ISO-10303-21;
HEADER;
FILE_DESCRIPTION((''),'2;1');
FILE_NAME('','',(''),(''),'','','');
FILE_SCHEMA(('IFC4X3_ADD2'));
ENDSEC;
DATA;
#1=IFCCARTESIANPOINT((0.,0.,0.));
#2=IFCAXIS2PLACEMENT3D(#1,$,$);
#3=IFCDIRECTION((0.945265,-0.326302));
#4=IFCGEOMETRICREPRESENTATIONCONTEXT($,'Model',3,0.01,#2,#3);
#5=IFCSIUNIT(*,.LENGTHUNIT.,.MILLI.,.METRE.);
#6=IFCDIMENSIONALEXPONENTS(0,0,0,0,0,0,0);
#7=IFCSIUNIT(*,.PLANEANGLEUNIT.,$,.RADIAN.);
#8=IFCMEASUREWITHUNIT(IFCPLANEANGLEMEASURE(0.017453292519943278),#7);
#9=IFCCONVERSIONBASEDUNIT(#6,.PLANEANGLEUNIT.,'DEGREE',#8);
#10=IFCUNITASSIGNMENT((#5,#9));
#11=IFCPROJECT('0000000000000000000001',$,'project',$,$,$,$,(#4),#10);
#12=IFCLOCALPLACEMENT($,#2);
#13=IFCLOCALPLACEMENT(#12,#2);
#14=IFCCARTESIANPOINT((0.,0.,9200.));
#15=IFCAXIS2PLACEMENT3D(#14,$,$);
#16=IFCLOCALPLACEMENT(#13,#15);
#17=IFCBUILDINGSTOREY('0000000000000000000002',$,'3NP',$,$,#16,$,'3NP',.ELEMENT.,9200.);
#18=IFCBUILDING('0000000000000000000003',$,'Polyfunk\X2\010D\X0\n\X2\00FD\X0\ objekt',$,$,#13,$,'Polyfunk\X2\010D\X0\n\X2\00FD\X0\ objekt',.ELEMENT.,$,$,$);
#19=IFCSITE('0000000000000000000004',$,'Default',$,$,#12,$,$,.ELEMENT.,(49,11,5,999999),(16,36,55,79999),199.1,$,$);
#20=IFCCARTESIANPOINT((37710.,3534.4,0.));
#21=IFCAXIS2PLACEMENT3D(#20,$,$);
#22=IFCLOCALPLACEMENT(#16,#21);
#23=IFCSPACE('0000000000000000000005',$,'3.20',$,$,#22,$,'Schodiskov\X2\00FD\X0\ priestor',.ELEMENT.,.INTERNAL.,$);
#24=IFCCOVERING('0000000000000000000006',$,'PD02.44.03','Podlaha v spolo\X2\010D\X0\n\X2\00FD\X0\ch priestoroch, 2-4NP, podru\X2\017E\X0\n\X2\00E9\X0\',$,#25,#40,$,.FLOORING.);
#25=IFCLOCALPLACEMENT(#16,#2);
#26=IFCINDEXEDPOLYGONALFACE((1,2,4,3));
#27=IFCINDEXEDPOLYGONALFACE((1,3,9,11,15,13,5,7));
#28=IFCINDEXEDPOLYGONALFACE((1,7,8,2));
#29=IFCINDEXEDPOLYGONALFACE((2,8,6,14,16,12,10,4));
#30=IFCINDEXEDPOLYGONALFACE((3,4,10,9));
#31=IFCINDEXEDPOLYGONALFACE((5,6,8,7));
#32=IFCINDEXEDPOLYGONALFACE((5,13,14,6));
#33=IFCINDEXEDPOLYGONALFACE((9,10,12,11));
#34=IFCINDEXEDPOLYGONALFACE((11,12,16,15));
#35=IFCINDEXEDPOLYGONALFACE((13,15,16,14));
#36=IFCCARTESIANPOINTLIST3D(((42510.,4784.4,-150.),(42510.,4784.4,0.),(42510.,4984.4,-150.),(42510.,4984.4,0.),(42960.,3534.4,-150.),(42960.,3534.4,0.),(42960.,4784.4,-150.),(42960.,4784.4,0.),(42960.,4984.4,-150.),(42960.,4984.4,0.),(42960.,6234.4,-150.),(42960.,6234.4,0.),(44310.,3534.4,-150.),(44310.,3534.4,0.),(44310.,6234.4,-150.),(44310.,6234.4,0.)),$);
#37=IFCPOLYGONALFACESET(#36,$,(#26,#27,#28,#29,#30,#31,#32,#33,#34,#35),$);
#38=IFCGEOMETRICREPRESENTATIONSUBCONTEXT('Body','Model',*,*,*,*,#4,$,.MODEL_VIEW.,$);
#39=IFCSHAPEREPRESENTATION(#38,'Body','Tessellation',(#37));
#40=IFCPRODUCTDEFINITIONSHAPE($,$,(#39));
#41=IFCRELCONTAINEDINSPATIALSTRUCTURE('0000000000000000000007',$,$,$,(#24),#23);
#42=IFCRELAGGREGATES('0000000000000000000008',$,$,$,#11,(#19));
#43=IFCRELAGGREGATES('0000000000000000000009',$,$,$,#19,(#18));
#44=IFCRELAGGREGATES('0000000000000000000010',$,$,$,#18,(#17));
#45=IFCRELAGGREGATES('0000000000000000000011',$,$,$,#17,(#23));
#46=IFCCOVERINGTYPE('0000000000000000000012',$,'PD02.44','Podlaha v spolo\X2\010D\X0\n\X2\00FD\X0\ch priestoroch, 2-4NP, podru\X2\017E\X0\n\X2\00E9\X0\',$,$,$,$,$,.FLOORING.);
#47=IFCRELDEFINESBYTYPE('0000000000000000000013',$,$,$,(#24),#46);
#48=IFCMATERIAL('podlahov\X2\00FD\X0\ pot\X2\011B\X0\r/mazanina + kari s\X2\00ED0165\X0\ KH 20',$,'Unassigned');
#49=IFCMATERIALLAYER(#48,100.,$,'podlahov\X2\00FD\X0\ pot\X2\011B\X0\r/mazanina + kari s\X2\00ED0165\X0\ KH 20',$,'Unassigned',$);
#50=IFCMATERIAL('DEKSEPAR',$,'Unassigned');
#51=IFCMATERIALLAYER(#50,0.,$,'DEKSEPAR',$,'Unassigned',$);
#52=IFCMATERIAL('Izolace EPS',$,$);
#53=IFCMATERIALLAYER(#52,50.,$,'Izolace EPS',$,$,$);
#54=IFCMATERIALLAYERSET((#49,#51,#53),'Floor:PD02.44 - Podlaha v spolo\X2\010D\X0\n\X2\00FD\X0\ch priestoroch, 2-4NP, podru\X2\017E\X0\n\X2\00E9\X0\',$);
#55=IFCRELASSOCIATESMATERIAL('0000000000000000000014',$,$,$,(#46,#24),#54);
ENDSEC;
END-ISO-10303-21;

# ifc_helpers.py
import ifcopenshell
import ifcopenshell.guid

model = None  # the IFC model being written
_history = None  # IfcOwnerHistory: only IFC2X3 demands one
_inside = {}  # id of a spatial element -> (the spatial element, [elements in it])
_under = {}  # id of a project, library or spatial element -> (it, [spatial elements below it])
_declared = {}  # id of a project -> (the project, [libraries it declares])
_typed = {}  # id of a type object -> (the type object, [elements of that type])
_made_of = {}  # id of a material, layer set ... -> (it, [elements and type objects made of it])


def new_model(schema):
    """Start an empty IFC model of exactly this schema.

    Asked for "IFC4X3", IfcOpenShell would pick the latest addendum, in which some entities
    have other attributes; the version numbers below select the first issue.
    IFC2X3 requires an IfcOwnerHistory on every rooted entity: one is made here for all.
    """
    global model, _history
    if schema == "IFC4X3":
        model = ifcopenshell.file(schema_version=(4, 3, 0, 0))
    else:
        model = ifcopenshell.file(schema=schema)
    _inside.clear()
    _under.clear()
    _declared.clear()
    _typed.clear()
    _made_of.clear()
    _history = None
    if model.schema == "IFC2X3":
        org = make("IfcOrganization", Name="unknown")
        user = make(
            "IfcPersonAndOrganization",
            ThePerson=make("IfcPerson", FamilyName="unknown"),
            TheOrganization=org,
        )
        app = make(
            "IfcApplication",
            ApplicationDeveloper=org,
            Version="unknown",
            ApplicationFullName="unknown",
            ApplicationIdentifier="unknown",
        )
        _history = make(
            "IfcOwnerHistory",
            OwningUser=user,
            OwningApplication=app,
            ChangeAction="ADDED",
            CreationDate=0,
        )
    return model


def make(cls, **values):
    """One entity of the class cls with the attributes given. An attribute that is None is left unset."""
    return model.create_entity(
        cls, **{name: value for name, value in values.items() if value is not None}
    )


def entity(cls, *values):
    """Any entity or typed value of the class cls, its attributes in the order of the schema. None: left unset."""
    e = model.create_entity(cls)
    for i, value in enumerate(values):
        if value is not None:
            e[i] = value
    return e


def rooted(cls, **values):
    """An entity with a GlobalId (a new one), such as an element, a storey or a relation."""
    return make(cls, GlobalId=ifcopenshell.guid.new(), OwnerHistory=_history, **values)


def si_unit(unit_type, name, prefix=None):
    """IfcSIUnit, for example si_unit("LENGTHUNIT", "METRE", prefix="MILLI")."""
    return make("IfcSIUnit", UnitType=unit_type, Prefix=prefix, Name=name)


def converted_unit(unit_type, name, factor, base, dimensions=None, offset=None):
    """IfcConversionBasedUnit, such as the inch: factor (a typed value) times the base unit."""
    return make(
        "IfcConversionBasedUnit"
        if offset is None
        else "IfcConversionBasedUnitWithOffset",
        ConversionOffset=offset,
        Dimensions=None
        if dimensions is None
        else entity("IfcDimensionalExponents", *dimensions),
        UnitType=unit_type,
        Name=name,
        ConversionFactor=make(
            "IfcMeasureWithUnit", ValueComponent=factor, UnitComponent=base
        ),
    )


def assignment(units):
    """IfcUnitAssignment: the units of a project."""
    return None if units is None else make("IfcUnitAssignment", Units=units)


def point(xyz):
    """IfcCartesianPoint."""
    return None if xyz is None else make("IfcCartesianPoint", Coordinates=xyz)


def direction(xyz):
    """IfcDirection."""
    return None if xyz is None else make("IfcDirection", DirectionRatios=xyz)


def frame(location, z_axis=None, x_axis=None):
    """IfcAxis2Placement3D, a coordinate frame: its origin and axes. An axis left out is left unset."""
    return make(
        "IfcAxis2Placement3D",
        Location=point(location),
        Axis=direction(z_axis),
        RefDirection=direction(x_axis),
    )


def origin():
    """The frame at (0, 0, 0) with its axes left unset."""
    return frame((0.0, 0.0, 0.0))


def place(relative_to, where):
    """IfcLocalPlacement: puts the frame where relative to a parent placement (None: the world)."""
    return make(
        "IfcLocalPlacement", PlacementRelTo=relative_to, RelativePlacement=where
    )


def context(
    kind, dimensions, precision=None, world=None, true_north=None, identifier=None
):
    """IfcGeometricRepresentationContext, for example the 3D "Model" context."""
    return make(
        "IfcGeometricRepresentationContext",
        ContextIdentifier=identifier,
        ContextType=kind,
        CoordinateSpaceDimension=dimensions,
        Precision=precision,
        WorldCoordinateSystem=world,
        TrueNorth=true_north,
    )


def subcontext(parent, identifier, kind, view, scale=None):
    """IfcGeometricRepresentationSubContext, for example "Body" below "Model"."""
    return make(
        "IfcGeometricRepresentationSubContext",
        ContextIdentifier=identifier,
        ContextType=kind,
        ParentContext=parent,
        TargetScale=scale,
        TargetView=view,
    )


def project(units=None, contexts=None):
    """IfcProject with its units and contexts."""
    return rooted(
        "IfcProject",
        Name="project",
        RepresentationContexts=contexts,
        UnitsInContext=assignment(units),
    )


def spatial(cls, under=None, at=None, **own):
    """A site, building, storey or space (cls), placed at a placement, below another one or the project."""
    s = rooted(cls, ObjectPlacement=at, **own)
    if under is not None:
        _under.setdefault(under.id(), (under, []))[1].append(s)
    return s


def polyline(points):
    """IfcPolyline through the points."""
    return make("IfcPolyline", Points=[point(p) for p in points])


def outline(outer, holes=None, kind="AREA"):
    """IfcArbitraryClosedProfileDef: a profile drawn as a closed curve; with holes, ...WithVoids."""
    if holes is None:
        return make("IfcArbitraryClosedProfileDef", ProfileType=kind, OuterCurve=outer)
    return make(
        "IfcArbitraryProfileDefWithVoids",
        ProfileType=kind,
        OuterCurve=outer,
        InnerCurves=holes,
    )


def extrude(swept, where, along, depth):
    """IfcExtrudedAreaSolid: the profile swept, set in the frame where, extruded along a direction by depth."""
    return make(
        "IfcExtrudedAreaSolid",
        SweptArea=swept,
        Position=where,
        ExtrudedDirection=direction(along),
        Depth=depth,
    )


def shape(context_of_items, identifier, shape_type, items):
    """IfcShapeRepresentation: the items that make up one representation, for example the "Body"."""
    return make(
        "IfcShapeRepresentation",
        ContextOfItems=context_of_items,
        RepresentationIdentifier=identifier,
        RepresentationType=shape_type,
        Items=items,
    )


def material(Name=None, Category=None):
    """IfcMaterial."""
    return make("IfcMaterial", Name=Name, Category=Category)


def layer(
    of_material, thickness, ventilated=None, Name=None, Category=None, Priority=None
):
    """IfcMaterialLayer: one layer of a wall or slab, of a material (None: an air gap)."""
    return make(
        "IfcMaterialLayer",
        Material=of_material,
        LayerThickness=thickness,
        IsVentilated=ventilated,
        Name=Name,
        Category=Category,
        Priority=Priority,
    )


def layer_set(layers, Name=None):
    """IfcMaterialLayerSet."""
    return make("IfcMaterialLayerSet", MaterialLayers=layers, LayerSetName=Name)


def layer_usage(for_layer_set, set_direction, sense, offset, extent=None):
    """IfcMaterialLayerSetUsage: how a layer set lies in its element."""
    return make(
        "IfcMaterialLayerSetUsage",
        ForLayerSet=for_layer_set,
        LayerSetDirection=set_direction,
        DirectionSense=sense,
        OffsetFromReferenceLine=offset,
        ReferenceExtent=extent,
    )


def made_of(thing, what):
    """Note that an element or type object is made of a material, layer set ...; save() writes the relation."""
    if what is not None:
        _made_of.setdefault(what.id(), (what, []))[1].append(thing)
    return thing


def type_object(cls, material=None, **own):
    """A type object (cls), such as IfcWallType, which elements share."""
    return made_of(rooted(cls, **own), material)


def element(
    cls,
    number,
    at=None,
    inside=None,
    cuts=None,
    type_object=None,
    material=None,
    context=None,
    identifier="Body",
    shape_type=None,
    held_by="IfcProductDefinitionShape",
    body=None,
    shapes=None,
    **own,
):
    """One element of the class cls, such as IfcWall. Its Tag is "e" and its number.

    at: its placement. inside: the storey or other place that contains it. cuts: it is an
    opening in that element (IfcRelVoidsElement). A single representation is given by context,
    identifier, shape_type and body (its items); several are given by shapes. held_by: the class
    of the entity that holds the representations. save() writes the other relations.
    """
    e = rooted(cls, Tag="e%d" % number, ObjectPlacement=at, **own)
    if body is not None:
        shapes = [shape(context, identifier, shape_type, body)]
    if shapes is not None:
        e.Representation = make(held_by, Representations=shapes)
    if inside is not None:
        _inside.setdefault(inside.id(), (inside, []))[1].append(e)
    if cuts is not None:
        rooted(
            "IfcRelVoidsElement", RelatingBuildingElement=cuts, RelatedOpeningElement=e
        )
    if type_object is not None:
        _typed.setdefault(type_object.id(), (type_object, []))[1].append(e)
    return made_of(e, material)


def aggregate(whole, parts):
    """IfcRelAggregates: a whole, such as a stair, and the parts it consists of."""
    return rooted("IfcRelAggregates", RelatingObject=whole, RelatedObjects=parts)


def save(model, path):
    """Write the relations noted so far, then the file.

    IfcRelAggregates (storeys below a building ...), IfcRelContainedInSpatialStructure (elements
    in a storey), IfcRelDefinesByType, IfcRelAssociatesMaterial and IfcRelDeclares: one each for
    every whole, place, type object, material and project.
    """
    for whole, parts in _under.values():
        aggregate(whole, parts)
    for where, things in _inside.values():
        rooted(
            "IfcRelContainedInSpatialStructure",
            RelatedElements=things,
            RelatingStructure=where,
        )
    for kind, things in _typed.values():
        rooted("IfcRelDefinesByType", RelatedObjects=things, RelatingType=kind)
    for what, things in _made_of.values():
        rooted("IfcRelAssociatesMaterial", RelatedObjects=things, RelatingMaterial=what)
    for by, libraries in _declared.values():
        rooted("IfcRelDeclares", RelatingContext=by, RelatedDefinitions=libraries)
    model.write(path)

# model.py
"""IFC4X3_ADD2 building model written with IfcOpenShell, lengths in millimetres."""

from ifc_helpers import new_model, entity, si_unit, converted_unit, direction, frame, origin, place, context, subcontext, project, spatial, polyline, outline, extrude, material, layer, layer_set, layer_usage, type_object, element, save


model = new_model("IFC4X3_ADD2")

# Units and contexts
model_context = context("Model", 3, precision=0.01, world=origin(), true_north=direction((0.945265, -0.326302)))
body_context = subcontext(model_context, "Body", "Model", "MODEL_VIEW")
ifc_project = project(units=[si_unit("LENGTHUNIT", "METRE", prefix="MILLI"), converted_unit("PLANEANGLEUNIT", "DEGREE", entity("IfcPlaneAngleMeasure", 0.017453292519943278), si_unit("PLANEANGLEUNIT", "RADIAN"), dimensions=[0, 0, 0, 0, 0, 0, 0])], contexts=[model_context])

# Site, building, storey
site_placement = place(None, origin())
site = spatial("IfcSite", under=ifc_project, at=site_placement, Name="Default", CompositionType="ELEMENT", RefLatitude=(49, 11, 5, 999999), RefLongitude=(16, 36, 55, 79999), RefElevation=199.1)
building_placement = place(site_placement, origin())
building = spatial("IfcBuilding", under=site, at=building_placement, Name="Polyfunkčný objekt", LongName="Polyfunkčný objekt", CompositionType="ELEMENT")
storey_placement = place(building_placement, frame((0.0, 0.0, 9200.0)))
storey = spatial("IfcBuildingStorey", under=building, at=storey_placement, Name="3NP", LongName="3NP", CompositionType="ELEMENT", Elevation=9200.0)

# Shared definitions
space_1_placement = place(storey_placement, frame((37710.0, 3534.4, 0.0)))
space_1 = spatial("IfcSpace", under=storey, at=space_1_placement, Name="3.20", LongName="Schodiskový priestor", CompositionType="ELEMENT", PredefinedType="INTERNAL")

# Covering
ifc_material_1 = material(Name="podlahový potěr/mazanina + kari síť KH 20", Category="Unassigned")
ifc_layer_1 = layer(ifc_material_1, 100.0, Name="podlahový potěr/mazanina + kari síť KH 20", Category="Unassigned")
ifc_material_2 = material(Name="DEKSEPAR", Category="Unassigned")
ifc_layer_2 = layer(ifc_material_2, 0.0, Name="DEKSEPAR", Category="Unassigned")
ifc_material_3 = material(Name="Izolace EPS")
ifc_layer_3 = layer(ifc_material_3, 50.0, Name="Izolace EPS")
ifc_layer_set_1 = layer_set([ifc_layer_1, ifc_layer_2, ifc_layer_3], Name="Floor:PD02.44 - Podlaha v spoločných priestoroch, 2-4NP, podružné")
ifc_layer_usage_1 = layer_usage(ifc_layer_set_1, "AXIS3", "POSITIVE", 0.0)
covering_type_1 = type_object("IfcCoveringType", Name="PD02.44", Description="Podlaha v spoločných priestoroch, 2-4NP, podružné", PredefinedType="FLOORING", material=ifc_layer_set_1)
covering_1_placement = place(storey_placement, origin())
element("IfcCovering", 1, at=covering_1_placement, inside=space_1, type_object=covering_type_1, material=ifc_layer_usage_1, Name="PD02.44.03", Description="Podlaha v spoločných priestoroch, 2-4NP, podružné", PredefinedType="FLOORING", context=body_context, shape_type="SweptSolid", body=[
    extrude(outline(polyline([(-100.0, -675.0), (100.0, -675.0), (100.0, -225.0), (1350.0, -225.0), (1350.0, 1125.0), (-1350.0, 1125.0), (-1350.0, -225.0), (-100.0, -225.0), (-100.0, -675.0)])), frame((43185.0, 4884.4, 0.0), z_axis=(0.0, 0.0, -1.0), x_axis=(0.0, 1.0, 0.0)), (0.0, 0.0, 1.0), 150.0),
])

save(model, "model.ifc")
